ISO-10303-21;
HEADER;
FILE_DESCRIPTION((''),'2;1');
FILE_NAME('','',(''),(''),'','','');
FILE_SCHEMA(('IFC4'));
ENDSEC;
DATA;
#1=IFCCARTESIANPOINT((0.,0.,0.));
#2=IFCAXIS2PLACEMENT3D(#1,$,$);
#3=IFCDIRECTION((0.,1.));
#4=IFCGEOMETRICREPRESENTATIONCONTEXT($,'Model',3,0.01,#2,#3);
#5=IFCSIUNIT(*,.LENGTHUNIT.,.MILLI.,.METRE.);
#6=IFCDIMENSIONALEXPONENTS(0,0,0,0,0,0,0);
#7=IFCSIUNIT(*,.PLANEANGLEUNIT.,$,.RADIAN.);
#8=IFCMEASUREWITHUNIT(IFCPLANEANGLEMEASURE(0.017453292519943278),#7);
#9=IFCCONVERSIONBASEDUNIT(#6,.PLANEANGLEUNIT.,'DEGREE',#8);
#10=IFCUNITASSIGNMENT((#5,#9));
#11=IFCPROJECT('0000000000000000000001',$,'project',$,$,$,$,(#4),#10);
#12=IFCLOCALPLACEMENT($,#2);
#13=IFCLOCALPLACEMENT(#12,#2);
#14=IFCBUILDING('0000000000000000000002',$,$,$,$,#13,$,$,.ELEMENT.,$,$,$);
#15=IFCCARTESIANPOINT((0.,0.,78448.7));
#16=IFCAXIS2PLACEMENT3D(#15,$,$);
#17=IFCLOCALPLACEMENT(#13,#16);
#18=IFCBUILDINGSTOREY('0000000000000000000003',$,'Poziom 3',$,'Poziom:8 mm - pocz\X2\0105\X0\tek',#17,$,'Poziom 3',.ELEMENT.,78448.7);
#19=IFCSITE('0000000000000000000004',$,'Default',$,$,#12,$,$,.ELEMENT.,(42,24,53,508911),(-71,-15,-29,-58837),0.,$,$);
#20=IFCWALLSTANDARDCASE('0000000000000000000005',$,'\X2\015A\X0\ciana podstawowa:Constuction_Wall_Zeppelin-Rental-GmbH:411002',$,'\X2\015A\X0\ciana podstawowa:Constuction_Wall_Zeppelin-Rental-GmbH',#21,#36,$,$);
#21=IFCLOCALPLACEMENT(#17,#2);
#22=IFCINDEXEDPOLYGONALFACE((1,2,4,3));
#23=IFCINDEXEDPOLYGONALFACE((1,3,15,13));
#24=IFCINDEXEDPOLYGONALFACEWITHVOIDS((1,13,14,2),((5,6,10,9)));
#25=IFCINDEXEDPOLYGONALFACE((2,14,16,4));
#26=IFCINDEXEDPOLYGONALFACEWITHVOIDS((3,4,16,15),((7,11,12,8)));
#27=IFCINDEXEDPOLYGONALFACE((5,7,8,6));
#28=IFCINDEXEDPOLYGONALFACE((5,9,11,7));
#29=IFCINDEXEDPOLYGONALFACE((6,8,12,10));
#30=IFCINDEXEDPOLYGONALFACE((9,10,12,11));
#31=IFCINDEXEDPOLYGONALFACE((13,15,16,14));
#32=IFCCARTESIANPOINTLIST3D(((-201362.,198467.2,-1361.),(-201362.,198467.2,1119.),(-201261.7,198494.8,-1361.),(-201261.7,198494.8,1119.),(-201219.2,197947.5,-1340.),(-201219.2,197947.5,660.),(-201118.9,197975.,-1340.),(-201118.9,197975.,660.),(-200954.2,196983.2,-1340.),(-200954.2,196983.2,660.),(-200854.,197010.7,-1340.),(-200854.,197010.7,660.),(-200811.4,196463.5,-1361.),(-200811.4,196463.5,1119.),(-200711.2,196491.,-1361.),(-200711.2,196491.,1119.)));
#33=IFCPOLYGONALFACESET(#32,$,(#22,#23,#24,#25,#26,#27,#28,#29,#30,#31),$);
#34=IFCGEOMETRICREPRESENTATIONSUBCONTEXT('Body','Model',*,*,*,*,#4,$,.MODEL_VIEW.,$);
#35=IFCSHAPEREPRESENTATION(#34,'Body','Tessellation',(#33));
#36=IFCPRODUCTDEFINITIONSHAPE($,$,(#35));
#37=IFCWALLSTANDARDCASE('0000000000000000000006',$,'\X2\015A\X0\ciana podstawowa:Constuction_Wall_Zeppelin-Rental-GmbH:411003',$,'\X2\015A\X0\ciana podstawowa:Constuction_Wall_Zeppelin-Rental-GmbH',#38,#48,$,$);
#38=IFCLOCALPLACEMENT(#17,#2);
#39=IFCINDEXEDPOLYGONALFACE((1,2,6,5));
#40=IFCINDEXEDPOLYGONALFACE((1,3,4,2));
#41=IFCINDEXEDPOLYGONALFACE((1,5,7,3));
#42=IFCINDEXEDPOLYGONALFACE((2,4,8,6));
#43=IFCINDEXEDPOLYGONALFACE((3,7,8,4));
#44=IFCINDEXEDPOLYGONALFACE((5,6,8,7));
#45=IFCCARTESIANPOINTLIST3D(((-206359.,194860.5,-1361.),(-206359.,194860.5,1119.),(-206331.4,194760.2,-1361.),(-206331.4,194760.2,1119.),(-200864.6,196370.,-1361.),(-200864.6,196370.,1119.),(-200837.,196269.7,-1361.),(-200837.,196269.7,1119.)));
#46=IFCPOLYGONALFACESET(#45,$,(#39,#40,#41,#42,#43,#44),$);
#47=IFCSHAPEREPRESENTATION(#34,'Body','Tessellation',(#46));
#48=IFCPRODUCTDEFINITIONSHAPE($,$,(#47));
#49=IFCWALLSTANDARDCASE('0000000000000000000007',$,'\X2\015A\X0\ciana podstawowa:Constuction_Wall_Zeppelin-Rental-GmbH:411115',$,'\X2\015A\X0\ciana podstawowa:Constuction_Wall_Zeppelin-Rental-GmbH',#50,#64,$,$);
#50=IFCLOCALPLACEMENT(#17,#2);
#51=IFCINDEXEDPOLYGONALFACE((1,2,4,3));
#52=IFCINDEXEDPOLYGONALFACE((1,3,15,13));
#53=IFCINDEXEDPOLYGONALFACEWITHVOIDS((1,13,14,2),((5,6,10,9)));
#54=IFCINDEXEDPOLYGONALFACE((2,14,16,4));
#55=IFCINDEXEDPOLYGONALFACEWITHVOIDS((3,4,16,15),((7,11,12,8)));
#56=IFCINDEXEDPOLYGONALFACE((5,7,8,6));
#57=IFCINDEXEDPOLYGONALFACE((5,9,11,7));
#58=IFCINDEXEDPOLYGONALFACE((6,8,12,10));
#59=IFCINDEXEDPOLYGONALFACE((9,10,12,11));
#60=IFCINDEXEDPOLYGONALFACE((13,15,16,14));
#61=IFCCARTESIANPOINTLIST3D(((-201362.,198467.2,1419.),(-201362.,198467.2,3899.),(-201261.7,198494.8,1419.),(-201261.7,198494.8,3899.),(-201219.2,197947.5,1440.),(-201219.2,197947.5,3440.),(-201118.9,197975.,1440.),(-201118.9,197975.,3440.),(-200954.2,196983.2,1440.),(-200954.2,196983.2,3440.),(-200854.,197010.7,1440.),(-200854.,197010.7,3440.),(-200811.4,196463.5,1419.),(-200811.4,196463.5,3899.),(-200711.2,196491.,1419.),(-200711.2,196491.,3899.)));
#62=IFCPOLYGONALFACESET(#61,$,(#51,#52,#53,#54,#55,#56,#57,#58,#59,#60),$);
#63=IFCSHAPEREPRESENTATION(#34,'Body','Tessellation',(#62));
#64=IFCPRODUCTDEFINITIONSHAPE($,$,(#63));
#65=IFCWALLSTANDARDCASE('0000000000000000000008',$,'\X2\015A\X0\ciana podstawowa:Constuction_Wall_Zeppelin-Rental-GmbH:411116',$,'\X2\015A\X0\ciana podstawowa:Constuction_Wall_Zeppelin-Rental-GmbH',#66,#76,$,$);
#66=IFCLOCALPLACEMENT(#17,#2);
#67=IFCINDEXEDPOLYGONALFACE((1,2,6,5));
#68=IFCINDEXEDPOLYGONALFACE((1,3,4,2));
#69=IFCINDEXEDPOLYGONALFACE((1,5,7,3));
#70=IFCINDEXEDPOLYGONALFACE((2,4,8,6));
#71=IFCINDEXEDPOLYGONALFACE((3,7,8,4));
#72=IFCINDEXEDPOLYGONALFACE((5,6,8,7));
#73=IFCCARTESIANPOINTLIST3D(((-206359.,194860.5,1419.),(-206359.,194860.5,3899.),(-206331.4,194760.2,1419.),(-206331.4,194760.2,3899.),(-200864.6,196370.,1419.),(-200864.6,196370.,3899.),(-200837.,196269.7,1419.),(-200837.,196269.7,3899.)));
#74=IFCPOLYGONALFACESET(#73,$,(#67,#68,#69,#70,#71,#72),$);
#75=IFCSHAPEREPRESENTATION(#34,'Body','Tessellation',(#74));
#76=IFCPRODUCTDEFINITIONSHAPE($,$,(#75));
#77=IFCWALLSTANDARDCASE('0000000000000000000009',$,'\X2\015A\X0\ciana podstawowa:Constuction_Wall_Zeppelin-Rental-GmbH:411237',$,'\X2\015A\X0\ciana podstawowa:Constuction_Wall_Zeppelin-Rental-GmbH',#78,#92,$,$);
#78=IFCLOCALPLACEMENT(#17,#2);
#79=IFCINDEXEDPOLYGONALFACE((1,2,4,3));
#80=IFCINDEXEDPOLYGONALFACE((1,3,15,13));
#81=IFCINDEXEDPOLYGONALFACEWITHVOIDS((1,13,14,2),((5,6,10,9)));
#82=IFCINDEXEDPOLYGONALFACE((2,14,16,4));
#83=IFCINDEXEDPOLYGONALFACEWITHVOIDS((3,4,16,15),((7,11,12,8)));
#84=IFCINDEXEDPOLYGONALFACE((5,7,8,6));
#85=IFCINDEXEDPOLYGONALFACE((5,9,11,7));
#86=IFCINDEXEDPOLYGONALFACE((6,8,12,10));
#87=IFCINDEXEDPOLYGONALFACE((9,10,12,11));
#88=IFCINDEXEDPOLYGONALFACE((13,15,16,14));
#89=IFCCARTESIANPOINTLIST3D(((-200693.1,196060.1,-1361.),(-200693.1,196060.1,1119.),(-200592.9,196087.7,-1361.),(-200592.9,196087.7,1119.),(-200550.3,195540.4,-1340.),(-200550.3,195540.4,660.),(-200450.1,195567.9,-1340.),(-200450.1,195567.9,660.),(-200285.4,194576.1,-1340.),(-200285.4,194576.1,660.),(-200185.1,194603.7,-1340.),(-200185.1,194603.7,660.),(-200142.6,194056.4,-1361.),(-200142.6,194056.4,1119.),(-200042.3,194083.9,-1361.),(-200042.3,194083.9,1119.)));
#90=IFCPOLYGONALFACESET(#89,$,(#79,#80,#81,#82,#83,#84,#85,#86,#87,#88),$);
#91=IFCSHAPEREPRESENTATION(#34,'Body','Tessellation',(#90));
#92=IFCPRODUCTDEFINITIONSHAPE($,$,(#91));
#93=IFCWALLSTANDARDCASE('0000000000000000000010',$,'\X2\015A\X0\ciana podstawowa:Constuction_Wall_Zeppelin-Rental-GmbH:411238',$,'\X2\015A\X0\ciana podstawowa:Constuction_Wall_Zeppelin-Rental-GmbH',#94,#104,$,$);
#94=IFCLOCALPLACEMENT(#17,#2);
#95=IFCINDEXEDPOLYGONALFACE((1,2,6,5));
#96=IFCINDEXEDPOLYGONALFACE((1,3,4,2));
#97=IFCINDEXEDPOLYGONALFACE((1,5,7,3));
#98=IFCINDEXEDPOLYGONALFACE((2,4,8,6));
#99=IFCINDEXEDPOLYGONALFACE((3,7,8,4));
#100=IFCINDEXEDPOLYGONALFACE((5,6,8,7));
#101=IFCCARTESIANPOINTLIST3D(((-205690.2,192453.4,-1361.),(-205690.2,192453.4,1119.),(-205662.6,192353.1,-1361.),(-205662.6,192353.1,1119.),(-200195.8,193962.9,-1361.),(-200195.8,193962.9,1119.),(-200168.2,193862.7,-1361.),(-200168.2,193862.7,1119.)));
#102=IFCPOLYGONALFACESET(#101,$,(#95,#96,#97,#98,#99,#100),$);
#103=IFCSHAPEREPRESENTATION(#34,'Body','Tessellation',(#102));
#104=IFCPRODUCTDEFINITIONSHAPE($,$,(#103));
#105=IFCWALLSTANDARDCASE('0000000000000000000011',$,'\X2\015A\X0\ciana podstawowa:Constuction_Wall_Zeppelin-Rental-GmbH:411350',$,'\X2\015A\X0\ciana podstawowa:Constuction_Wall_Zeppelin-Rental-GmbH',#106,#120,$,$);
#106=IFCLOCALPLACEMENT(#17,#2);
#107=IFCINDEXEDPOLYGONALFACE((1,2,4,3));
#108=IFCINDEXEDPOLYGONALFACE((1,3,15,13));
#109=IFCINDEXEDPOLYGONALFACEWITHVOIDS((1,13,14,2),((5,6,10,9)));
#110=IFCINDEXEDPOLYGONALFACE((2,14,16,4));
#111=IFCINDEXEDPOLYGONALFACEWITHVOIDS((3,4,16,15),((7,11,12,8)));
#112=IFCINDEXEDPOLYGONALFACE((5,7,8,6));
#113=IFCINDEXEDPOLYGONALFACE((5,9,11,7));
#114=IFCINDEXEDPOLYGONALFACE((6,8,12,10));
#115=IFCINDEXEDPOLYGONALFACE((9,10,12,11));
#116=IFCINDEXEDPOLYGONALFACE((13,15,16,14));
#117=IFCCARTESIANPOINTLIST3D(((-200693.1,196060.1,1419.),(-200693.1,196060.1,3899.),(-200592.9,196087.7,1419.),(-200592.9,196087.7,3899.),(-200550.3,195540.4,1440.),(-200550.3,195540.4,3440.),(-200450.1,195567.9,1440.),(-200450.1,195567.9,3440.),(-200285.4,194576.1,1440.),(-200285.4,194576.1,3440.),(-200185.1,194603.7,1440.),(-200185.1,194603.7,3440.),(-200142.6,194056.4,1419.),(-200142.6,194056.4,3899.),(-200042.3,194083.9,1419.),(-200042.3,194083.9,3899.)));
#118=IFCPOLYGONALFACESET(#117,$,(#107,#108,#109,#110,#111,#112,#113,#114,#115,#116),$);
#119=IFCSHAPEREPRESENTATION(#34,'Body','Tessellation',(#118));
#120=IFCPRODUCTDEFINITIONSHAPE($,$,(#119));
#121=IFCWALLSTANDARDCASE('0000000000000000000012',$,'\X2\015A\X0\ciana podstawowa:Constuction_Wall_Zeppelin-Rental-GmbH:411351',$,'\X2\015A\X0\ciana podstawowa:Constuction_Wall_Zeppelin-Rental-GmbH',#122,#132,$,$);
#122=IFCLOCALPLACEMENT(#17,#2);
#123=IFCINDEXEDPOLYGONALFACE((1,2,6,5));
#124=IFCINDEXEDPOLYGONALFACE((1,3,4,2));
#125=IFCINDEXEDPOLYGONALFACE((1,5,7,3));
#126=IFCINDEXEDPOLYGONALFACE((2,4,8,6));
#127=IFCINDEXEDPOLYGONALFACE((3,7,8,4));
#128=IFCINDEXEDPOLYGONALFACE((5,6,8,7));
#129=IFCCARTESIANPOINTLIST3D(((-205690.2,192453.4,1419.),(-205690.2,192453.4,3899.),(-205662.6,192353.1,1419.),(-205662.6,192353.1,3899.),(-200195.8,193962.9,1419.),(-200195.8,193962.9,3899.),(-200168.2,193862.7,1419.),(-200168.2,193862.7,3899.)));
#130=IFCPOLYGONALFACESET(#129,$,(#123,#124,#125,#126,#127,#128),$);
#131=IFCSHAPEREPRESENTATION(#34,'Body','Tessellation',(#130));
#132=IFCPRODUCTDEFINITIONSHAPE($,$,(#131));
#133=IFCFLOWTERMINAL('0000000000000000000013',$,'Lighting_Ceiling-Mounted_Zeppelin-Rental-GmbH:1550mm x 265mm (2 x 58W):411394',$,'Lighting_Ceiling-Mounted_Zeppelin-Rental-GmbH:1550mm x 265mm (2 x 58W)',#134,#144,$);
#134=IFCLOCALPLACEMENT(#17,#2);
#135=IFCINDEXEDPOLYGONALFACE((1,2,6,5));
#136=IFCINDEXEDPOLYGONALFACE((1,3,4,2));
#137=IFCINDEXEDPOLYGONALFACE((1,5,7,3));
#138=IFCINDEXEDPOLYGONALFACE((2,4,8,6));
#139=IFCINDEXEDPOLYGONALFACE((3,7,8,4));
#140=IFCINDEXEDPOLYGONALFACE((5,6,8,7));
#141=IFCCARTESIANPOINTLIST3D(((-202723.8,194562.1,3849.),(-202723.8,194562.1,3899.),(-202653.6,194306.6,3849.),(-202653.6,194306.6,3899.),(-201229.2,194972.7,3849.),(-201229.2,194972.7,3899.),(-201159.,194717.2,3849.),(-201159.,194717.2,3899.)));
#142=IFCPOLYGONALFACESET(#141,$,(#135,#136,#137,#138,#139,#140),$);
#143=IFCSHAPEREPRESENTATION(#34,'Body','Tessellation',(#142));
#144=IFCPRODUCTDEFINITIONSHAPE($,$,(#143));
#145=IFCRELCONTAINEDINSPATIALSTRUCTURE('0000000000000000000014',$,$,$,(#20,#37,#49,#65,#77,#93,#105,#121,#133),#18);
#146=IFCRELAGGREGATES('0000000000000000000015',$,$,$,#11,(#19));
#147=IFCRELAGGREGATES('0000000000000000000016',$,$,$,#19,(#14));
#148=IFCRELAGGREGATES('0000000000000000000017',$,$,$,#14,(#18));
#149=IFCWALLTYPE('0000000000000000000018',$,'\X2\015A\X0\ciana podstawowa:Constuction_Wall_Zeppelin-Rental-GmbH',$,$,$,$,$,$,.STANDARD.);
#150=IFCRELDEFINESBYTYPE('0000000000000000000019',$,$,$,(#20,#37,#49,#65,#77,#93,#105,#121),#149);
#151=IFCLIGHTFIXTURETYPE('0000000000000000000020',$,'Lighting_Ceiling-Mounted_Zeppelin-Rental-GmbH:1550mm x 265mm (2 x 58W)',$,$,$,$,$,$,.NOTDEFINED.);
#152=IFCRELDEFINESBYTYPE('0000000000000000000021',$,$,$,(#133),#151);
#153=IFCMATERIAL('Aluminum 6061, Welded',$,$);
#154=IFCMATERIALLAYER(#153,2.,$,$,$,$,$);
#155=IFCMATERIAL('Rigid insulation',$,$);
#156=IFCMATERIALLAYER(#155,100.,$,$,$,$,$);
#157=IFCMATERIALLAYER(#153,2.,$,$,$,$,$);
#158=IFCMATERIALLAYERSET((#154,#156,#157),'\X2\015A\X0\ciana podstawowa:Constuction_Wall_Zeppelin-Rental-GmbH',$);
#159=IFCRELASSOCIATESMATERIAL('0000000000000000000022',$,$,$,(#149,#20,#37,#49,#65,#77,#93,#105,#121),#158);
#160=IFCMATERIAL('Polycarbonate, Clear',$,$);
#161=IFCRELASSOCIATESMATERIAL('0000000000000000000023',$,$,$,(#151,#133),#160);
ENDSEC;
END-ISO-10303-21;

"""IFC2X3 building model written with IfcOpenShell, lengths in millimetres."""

from ifc_helpers import new_model, entity, si_unit, converted_unit, direction, frame, frame_2d, origin, origin_2d_with_axis, place, context, subcontext, project, spatial, rectangle, extrude, source, transform, mapped, material, layer, layer_set, layer_usage, type_object, type_shapes, element, save


model = new_model("IFC2X3")

# Units and contexts
model_context = context("Model", 3, precision=0.01, world=origin(), true_north=direction((0.0, 1.0)))
body_context = subcontext(model_context, "Body", "Model", "MODEL_VIEW")
ifc_project = project(units=[si_unit("LENGTHUNIT", "METRE", prefix="MILLI"), converted_unit("PLANEANGLEUNIT", "DEGREE", entity("IfcPlaneAngleMeasure", 0.017453292519943278), si_unit("PLANEANGLEUNIT", "RADIAN"), dimensions=[0, 0, 0, 0, 0, 0, 0])], contexts=[model_context])

# Site, building, storey
site_placement = place(None, origin())
site = spatial("IfcSite", under=ifc_project, at=site_placement, Name="Default", CompositionType="ELEMENT", RefLatitude=(42, 24, 53, 508911), RefLongitude=(-71, -15, -29, -58837), RefElevation=0.0)
building_placement = place(site_placement, origin())
building = spatial("IfcBuilding", under=site, at=building_placement, CompositionType="ELEMENT")
storey_placement = place(building_placement, frame((0.0, 0.0, 78448.7)))
storey = spatial("IfcBuildingStorey", under=building, at=storey_placement, Name="Poziom 3", ObjectType="Poziom:8 mm - początek", LongName="Poziom 3", CompositionType="ELEMENT", Elevation=78448.7)

# Shared definitions
ifc_material_1 = material(Name="Aluminum 6061, Welded")
ifc_layer_1 = layer(ifc_material_1, 2.0)
ifc_material_2 = material(Name="Rigid insulation")
ifc_layer_2 = layer(ifc_material_2, 100.0)
ifc_layer_3 = layer(ifc_material_1, 2.0)
ifc_layer_set_1 = layer_set([ifc_layer_1, ifc_layer_2, ifc_layer_3], Name="Ściana podstawowa:Constuction_Wall_Zeppelin-Rental-GmbH")
wall_type_1 = type_object("IfcWallType", Name="Ściana podstawowa:Constuction_Wall_Zeppelin-Rental-GmbH", PredefinedType="STANDARD", material=ifc_layer_set_1)

# Wall, opening
ifc_layer_usage_1 = layer_usage(ifc_layer_set_1, "AXIS2", "NEGATIVE", 52.0)
wall_1_placement = place(storey_placement, frame((-201311.8, 198481.0, -1361.0), z_axis=(0.0, 0.0, 1.0), x_axis=(0.264931, -0.964267, 0.0)))
wall_1 = element("IfcWallStandardCase", 1, at=wall_1_placement, inside=storey, type_object=wall_type_1, material=ifc_layer_usage_1, Name="Ściana podstawowa:Constuction_Wall_Zeppelin-Rental-GmbH:411002", ObjectType="Ściana podstawowa:Constuction_Wall_Zeppelin-Rental-GmbH", context=body_context, shape_type="SweptSolid", body=[
    extrude(rectangle(XDim=2078.0, YDim=104.0, at=frame_2d((1039.0, 0.0), x_axis=(-1.0, 0.0))), origin(), (0.0, 0.0, 1.0), 2480.0),
])
opening_1_placement = place(wall_1_placement, frame((539.0, -52.0, 21.0)))
element("IfcOpeningElement", 2, at=opening_1_placement, cuts=wall_1, ObjectType="Opening", context=body_context, shape_type="SweptSolid", body=[
    extrude(rectangle(XDim=2000.0, YDim=1000.0, at=frame_2d((1000.0, 500.0), x_axis=(1.0, 0.0))), frame((0.0, 0.0, 0.0), z_axis=(0.0, 1.0, 0.0), x_axis=(0.0, 0.0, 1.0)), (0.0, 0.0, 1.0), 104.0),
])

# Wall
ifc_layer_usage_2 = layer_usage(ifc_layer_set_1, "AXIS2", "NEGATIVE", 52.0)
wall_2_placement = place(storey_placement, frame((-200850.8, 196319.9, -1361.0), z_axis=(0.0, 0.0, 1.0), x_axis=(-0.964267, -0.264931, 0.0)))
element("IfcWallStandardCase", 3, at=wall_2_placement, inside=storey, type_object=wall_type_1, material=ifc_layer_usage_2, Name="Ściana podstawowa:Constuction_Wall_Zeppelin-Rental-GmbH:411003", ObjectType="Ściana podstawowa:Constuction_Wall_Zeppelin-Rental-GmbH", context=body_context, shape_type="SweptSolid", body=[
    extrude(rectangle(XDim=5698.0, YDim=104.0, at=frame_2d((2849.0, 0.0), x_axis=(-1.0, 0.0))), origin(), (0.0, 0.0, 1.0), 2480.0),
])

# Wall, opening
ifc_layer_usage_3 = layer_usage(ifc_layer_set_1, "AXIS2", "NEGATIVE", 52.0)
wall_3_placement = place(storey_placement, frame((-201311.8, 198481.0, 1419.0), z_axis=(0.0, 0.0, 1.0), x_axis=(0.264931, -0.964267, 0.0)))
wall_3 = element("IfcWallStandardCase", 4, at=wall_3_placement, inside=storey, type_object=wall_type_1, material=ifc_layer_usage_3, Name="Ściana podstawowa:Constuction_Wall_Zeppelin-Rental-GmbH:411115", ObjectType="Ściana podstawowa:Constuction_Wall_Zeppelin-Rental-GmbH", context=body_context, shape_type="SweptSolid", body=[
    extrude(rectangle(XDim=2078.0, YDim=104.0, at=frame_2d((1039.0, 0.0), x_axis=(-1.0, 0.0))), origin(), (0.0, 0.0, 1.0), 2480.0),
])
opening_2_placement = place(wall_3_placement, frame((539.0, -52.0, 21.0)))
element("IfcOpeningElement", 5, at=opening_2_placement, cuts=wall_3, ObjectType="Opening", context=body_context, shape_type="SweptSolid", body=[
    extrude(rectangle(XDim=2000.0, YDim=1000.0, at=frame_2d((1000.0, 500.0), x_axis=(1.0, 0.0))), frame((0.0, 0.0, 0.0), z_axis=(0.0, 1.0, 0.0), x_axis=(0.0, 0.0, 1.0)), (0.0, 0.0, 1.0), 104.0),
])

# Wall
ifc_layer_usage_4 = layer_usage(ifc_layer_set_1, "AXIS2", "NEGATIVE", 52.0)
wall_4_placement = place(storey_placement, frame((-200850.8, 196319.9, 1419.0), z_axis=(0.0, 0.0, 1.0), x_axis=(-0.964267, -0.264931, 0.0)))
element("IfcWallStandardCase", 6, at=wall_4_placement, inside=storey, type_object=wall_type_1, material=ifc_layer_usage_4, Name="Ściana podstawowa:Constuction_Wall_Zeppelin-Rental-GmbH:411116", ObjectType="Ściana podstawowa:Constuction_Wall_Zeppelin-Rental-GmbH", context=body_context, shape_type="SweptSolid", body=[
    extrude(rectangle(XDim=5698.0, YDim=104.0, at=frame_2d((2849.0, 0.0), x_axis=(-1.0, 0.0))), origin(), (0.0, 0.0, 1.0), 2480.0),
])

# Wall, opening
ifc_layer_usage_5 = layer_usage(ifc_layer_set_1, "AXIS2", "NEGATIVE", 52.0)
wall_5_placement = place(storey_placement, frame((-200643.0, 196073.9, -1361.0), z_axis=(0.0, 0.0, 1.0), x_axis=(0.264931, -0.964267, 0.0)))
wall_5 = element("IfcWallStandardCase", 7, at=wall_5_placement, inside=storey, type_object=wall_type_1, material=ifc_layer_usage_5, Name="Ściana podstawowa:Constuction_Wall_Zeppelin-Rental-GmbH:411237", ObjectType="Ściana podstawowa:Constuction_Wall_Zeppelin-Rental-GmbH", context=body_context, shape_type="SweptSolid", body=[
    extrude(rectangle(XDim=2078.0, YDim=104.0, at=frame_2d((1039.0, 0.0), x_axis=(-1.0, 0.0))), origin(), (0.0, 0.0, 1.0), 2480.0),
])
opening_3_placement = place(wall_5_placement, frame((539.0, -52.0, 21.0)))
element("IfcOpeningElement", 8, at=opening_3_placement, cuts=wall_5, ObjectType="Opening", context=body_context, shape_type="SweptSolid", body=[
    extrude(rectangle(XDim=2000.0, YDim=1000.0, at=frame_2d((1000.0, 500.0), x_axis=(1.0, 0.0))), frame((0.0, 0.0, 0.0), z_axis=(0.0, 1.0, 0.0), x_axis=(0.0, 0.0, 1.0)), (0.0, 0.0, 1.0), 104.0),
])

# Wall
ifc_layer_usage_6 = layer_usage(ifc_layer_set_1, "AXIS2", "NEGATIVE", 52.0)
wall_6_placement = place(storey_placement, frame((-200182.0, 193912.8, -1361.0), z_axis=(0.0, 0.0, 1.0), x_axis=(-0.964267, -0.264931, 0.0)))
element("IfcWallStandardCase", 9, at=wall_6_placement, inside=storey, type_object=wall_type_1, material=ifc_layer_usage_6, Name="Ściana podstawowa:Constuction_Wall_Zeppelin-Rental-GmbH:411238", ObjectType="Ściana podstawowa:Constuction_Wall_Zeppelin-Rental-GmbH", context=body_context, shape_type="SweptSolid", body=[
    extrude(rectangle(XDim=5698.0, YDim=104.0, at=frame_2d((2849.0, 0.0), x_axis=(-1.0, 0.0))), origin(), (0.0, 0.0, 1.0), 2480.0),
])

# Wall, opening
ifc_layer_usage_7 = layer_usage(ifc_layer_set_1, "AXIS2", "NEGATIVE", 52.0)
wall_7_placement = place(storey_placement, frame((-200643.0, 196073.9, 1419.0), z_axis=(0.0, 0.0, 1.0), x_axis=(0.264931, -0.964267, 0.0)))
wall_7 = element("IfcWallStandardCase", 10, at=wall_7_placement, inside=storey, type_object=wall_type_1, material=ifc_layer_usage_7, Name="Ściana podstawowa:Constuction_Wall_Zeppelin-Rental-GmbH:411350", ObjectType="Ściana podstawowa:Constuction_Wall_Zeppelin-Rental-GmbH", context=body_context, shape_type="SweptSolid", body=[
    extrude(rectangle(XDim=2078.0, YDim=104.0, at=frame_2d((1039.0, 0.0), x_axis=(-1.0, 0.0))), origin(), (0.0, 0.0, 1.0), 2480.0),
])
opening_4_placement = place(wall_7_placement, frame((539.0, -52.0, 21.0)))
element("IfcOpeningElement", 11, at=opening_4_placement, cuts=wall_7, ObjectType="Opening", context=body_context, shape_type="SweptSolid", body=[
    extrude(rectangle(XDim=2000.0, YDim=1000.0, at=frame_2d((1000.0, 500.0), x_axis=(1.0, 0.0))), frame((0.0, 0.0, 0.0), z_axis=(0.0, 1.0, 0.0), x_axis=(0.0, 0.0, 1.0)), (0.0, 0.0, 1.0), 104.0),
])

# Wall
ifc_layer_usage_8 = layer_usage(ifc_layer_set_1, "AXIS2", "NEGATIVE", 52.0)
wall_8_placement = place(storey_placement, frame((-200182.0, 193912.8, 1419.0), z_axis=(0.0, 0.0, 1.0), x_axis=(-0.964267, -0.264931, 0.0)))
element("IfcWallStandardCase", 12, at=wall_8_placement, inside=storey, type_object=wall_type_1, material=ifc_layer_usage_8, Name="Ściana podstawowa:Constuction_Wall_Zeppelin-Rental-GmbH:411351", ObjectType="Ściana podstawowa:Constuction_Wall_Zeppelin-Rental-GmbH", context=body_context, shape_type="SweptSolid", body=[
    extrude(rectangle(XDim=5698.0, YDim=104.0, at=frame_2d((2849.0, 0.0), x_axis=(-1.0, 0.0))), origin(), (0.0, 0.0, 1.0), 2480.0),
])

# Flow terminal
ifc_material_3 = material(Name="Polycarbonate, Clear")
light_fixture_type = type_object("IfcLightFixtureType", Name="Lighting_Ceiling-Mounted_Zeppelin-Rental-GmbH:1550mm x 265mm (2 x 58W)", PredefinedType="NOTDEFINED", material=ifc_material_3)
shared_shape = source(origin(), body_context, "Body", "SweptSolid", [
    extrude(rectangle(XDim=1550.0, YDim=265.0, at=origin_2d_with_axis()), frame((0.0, 0.0, 0.0), z_axis=(0.0, 0.0, 1.0), x_axis=(-1.0, 0.0, 0.0)), (0.0, 0.0, 1.0), 50.0),
])
type_shapes(light_fixture_type, [shared_shape])
flow_terminal_placement = place(storey_placement, frame((-201941.4, 194639.6, 3899.0), z_axis=(0.0, 0.0, -1.0), x_axis=(-0.964267, -0.264931, 0.0)))
element("IfcFlowTerminal", 13, at=flow_terminal_placement, inside=storey, type_object=light_fixture_type, material=ifc_material_3, Name="Lighting_Ceiling-Mounted_Zeppelin-Rental-GmbH:1550mm x 265mm (2 x 58W):411394", ObjectType="Lighting_Ceiling-Mounted_Zeppelin-Rental-GmbH:1550mm x 265mm (2 x 58W)", context=body_context, shape_type="MappedRepresentation", body=[
    mapped(shared_shape, transform((0.0, 0.0, 0.0), scale=1.0)),
])

save(model, "model.ifc")
